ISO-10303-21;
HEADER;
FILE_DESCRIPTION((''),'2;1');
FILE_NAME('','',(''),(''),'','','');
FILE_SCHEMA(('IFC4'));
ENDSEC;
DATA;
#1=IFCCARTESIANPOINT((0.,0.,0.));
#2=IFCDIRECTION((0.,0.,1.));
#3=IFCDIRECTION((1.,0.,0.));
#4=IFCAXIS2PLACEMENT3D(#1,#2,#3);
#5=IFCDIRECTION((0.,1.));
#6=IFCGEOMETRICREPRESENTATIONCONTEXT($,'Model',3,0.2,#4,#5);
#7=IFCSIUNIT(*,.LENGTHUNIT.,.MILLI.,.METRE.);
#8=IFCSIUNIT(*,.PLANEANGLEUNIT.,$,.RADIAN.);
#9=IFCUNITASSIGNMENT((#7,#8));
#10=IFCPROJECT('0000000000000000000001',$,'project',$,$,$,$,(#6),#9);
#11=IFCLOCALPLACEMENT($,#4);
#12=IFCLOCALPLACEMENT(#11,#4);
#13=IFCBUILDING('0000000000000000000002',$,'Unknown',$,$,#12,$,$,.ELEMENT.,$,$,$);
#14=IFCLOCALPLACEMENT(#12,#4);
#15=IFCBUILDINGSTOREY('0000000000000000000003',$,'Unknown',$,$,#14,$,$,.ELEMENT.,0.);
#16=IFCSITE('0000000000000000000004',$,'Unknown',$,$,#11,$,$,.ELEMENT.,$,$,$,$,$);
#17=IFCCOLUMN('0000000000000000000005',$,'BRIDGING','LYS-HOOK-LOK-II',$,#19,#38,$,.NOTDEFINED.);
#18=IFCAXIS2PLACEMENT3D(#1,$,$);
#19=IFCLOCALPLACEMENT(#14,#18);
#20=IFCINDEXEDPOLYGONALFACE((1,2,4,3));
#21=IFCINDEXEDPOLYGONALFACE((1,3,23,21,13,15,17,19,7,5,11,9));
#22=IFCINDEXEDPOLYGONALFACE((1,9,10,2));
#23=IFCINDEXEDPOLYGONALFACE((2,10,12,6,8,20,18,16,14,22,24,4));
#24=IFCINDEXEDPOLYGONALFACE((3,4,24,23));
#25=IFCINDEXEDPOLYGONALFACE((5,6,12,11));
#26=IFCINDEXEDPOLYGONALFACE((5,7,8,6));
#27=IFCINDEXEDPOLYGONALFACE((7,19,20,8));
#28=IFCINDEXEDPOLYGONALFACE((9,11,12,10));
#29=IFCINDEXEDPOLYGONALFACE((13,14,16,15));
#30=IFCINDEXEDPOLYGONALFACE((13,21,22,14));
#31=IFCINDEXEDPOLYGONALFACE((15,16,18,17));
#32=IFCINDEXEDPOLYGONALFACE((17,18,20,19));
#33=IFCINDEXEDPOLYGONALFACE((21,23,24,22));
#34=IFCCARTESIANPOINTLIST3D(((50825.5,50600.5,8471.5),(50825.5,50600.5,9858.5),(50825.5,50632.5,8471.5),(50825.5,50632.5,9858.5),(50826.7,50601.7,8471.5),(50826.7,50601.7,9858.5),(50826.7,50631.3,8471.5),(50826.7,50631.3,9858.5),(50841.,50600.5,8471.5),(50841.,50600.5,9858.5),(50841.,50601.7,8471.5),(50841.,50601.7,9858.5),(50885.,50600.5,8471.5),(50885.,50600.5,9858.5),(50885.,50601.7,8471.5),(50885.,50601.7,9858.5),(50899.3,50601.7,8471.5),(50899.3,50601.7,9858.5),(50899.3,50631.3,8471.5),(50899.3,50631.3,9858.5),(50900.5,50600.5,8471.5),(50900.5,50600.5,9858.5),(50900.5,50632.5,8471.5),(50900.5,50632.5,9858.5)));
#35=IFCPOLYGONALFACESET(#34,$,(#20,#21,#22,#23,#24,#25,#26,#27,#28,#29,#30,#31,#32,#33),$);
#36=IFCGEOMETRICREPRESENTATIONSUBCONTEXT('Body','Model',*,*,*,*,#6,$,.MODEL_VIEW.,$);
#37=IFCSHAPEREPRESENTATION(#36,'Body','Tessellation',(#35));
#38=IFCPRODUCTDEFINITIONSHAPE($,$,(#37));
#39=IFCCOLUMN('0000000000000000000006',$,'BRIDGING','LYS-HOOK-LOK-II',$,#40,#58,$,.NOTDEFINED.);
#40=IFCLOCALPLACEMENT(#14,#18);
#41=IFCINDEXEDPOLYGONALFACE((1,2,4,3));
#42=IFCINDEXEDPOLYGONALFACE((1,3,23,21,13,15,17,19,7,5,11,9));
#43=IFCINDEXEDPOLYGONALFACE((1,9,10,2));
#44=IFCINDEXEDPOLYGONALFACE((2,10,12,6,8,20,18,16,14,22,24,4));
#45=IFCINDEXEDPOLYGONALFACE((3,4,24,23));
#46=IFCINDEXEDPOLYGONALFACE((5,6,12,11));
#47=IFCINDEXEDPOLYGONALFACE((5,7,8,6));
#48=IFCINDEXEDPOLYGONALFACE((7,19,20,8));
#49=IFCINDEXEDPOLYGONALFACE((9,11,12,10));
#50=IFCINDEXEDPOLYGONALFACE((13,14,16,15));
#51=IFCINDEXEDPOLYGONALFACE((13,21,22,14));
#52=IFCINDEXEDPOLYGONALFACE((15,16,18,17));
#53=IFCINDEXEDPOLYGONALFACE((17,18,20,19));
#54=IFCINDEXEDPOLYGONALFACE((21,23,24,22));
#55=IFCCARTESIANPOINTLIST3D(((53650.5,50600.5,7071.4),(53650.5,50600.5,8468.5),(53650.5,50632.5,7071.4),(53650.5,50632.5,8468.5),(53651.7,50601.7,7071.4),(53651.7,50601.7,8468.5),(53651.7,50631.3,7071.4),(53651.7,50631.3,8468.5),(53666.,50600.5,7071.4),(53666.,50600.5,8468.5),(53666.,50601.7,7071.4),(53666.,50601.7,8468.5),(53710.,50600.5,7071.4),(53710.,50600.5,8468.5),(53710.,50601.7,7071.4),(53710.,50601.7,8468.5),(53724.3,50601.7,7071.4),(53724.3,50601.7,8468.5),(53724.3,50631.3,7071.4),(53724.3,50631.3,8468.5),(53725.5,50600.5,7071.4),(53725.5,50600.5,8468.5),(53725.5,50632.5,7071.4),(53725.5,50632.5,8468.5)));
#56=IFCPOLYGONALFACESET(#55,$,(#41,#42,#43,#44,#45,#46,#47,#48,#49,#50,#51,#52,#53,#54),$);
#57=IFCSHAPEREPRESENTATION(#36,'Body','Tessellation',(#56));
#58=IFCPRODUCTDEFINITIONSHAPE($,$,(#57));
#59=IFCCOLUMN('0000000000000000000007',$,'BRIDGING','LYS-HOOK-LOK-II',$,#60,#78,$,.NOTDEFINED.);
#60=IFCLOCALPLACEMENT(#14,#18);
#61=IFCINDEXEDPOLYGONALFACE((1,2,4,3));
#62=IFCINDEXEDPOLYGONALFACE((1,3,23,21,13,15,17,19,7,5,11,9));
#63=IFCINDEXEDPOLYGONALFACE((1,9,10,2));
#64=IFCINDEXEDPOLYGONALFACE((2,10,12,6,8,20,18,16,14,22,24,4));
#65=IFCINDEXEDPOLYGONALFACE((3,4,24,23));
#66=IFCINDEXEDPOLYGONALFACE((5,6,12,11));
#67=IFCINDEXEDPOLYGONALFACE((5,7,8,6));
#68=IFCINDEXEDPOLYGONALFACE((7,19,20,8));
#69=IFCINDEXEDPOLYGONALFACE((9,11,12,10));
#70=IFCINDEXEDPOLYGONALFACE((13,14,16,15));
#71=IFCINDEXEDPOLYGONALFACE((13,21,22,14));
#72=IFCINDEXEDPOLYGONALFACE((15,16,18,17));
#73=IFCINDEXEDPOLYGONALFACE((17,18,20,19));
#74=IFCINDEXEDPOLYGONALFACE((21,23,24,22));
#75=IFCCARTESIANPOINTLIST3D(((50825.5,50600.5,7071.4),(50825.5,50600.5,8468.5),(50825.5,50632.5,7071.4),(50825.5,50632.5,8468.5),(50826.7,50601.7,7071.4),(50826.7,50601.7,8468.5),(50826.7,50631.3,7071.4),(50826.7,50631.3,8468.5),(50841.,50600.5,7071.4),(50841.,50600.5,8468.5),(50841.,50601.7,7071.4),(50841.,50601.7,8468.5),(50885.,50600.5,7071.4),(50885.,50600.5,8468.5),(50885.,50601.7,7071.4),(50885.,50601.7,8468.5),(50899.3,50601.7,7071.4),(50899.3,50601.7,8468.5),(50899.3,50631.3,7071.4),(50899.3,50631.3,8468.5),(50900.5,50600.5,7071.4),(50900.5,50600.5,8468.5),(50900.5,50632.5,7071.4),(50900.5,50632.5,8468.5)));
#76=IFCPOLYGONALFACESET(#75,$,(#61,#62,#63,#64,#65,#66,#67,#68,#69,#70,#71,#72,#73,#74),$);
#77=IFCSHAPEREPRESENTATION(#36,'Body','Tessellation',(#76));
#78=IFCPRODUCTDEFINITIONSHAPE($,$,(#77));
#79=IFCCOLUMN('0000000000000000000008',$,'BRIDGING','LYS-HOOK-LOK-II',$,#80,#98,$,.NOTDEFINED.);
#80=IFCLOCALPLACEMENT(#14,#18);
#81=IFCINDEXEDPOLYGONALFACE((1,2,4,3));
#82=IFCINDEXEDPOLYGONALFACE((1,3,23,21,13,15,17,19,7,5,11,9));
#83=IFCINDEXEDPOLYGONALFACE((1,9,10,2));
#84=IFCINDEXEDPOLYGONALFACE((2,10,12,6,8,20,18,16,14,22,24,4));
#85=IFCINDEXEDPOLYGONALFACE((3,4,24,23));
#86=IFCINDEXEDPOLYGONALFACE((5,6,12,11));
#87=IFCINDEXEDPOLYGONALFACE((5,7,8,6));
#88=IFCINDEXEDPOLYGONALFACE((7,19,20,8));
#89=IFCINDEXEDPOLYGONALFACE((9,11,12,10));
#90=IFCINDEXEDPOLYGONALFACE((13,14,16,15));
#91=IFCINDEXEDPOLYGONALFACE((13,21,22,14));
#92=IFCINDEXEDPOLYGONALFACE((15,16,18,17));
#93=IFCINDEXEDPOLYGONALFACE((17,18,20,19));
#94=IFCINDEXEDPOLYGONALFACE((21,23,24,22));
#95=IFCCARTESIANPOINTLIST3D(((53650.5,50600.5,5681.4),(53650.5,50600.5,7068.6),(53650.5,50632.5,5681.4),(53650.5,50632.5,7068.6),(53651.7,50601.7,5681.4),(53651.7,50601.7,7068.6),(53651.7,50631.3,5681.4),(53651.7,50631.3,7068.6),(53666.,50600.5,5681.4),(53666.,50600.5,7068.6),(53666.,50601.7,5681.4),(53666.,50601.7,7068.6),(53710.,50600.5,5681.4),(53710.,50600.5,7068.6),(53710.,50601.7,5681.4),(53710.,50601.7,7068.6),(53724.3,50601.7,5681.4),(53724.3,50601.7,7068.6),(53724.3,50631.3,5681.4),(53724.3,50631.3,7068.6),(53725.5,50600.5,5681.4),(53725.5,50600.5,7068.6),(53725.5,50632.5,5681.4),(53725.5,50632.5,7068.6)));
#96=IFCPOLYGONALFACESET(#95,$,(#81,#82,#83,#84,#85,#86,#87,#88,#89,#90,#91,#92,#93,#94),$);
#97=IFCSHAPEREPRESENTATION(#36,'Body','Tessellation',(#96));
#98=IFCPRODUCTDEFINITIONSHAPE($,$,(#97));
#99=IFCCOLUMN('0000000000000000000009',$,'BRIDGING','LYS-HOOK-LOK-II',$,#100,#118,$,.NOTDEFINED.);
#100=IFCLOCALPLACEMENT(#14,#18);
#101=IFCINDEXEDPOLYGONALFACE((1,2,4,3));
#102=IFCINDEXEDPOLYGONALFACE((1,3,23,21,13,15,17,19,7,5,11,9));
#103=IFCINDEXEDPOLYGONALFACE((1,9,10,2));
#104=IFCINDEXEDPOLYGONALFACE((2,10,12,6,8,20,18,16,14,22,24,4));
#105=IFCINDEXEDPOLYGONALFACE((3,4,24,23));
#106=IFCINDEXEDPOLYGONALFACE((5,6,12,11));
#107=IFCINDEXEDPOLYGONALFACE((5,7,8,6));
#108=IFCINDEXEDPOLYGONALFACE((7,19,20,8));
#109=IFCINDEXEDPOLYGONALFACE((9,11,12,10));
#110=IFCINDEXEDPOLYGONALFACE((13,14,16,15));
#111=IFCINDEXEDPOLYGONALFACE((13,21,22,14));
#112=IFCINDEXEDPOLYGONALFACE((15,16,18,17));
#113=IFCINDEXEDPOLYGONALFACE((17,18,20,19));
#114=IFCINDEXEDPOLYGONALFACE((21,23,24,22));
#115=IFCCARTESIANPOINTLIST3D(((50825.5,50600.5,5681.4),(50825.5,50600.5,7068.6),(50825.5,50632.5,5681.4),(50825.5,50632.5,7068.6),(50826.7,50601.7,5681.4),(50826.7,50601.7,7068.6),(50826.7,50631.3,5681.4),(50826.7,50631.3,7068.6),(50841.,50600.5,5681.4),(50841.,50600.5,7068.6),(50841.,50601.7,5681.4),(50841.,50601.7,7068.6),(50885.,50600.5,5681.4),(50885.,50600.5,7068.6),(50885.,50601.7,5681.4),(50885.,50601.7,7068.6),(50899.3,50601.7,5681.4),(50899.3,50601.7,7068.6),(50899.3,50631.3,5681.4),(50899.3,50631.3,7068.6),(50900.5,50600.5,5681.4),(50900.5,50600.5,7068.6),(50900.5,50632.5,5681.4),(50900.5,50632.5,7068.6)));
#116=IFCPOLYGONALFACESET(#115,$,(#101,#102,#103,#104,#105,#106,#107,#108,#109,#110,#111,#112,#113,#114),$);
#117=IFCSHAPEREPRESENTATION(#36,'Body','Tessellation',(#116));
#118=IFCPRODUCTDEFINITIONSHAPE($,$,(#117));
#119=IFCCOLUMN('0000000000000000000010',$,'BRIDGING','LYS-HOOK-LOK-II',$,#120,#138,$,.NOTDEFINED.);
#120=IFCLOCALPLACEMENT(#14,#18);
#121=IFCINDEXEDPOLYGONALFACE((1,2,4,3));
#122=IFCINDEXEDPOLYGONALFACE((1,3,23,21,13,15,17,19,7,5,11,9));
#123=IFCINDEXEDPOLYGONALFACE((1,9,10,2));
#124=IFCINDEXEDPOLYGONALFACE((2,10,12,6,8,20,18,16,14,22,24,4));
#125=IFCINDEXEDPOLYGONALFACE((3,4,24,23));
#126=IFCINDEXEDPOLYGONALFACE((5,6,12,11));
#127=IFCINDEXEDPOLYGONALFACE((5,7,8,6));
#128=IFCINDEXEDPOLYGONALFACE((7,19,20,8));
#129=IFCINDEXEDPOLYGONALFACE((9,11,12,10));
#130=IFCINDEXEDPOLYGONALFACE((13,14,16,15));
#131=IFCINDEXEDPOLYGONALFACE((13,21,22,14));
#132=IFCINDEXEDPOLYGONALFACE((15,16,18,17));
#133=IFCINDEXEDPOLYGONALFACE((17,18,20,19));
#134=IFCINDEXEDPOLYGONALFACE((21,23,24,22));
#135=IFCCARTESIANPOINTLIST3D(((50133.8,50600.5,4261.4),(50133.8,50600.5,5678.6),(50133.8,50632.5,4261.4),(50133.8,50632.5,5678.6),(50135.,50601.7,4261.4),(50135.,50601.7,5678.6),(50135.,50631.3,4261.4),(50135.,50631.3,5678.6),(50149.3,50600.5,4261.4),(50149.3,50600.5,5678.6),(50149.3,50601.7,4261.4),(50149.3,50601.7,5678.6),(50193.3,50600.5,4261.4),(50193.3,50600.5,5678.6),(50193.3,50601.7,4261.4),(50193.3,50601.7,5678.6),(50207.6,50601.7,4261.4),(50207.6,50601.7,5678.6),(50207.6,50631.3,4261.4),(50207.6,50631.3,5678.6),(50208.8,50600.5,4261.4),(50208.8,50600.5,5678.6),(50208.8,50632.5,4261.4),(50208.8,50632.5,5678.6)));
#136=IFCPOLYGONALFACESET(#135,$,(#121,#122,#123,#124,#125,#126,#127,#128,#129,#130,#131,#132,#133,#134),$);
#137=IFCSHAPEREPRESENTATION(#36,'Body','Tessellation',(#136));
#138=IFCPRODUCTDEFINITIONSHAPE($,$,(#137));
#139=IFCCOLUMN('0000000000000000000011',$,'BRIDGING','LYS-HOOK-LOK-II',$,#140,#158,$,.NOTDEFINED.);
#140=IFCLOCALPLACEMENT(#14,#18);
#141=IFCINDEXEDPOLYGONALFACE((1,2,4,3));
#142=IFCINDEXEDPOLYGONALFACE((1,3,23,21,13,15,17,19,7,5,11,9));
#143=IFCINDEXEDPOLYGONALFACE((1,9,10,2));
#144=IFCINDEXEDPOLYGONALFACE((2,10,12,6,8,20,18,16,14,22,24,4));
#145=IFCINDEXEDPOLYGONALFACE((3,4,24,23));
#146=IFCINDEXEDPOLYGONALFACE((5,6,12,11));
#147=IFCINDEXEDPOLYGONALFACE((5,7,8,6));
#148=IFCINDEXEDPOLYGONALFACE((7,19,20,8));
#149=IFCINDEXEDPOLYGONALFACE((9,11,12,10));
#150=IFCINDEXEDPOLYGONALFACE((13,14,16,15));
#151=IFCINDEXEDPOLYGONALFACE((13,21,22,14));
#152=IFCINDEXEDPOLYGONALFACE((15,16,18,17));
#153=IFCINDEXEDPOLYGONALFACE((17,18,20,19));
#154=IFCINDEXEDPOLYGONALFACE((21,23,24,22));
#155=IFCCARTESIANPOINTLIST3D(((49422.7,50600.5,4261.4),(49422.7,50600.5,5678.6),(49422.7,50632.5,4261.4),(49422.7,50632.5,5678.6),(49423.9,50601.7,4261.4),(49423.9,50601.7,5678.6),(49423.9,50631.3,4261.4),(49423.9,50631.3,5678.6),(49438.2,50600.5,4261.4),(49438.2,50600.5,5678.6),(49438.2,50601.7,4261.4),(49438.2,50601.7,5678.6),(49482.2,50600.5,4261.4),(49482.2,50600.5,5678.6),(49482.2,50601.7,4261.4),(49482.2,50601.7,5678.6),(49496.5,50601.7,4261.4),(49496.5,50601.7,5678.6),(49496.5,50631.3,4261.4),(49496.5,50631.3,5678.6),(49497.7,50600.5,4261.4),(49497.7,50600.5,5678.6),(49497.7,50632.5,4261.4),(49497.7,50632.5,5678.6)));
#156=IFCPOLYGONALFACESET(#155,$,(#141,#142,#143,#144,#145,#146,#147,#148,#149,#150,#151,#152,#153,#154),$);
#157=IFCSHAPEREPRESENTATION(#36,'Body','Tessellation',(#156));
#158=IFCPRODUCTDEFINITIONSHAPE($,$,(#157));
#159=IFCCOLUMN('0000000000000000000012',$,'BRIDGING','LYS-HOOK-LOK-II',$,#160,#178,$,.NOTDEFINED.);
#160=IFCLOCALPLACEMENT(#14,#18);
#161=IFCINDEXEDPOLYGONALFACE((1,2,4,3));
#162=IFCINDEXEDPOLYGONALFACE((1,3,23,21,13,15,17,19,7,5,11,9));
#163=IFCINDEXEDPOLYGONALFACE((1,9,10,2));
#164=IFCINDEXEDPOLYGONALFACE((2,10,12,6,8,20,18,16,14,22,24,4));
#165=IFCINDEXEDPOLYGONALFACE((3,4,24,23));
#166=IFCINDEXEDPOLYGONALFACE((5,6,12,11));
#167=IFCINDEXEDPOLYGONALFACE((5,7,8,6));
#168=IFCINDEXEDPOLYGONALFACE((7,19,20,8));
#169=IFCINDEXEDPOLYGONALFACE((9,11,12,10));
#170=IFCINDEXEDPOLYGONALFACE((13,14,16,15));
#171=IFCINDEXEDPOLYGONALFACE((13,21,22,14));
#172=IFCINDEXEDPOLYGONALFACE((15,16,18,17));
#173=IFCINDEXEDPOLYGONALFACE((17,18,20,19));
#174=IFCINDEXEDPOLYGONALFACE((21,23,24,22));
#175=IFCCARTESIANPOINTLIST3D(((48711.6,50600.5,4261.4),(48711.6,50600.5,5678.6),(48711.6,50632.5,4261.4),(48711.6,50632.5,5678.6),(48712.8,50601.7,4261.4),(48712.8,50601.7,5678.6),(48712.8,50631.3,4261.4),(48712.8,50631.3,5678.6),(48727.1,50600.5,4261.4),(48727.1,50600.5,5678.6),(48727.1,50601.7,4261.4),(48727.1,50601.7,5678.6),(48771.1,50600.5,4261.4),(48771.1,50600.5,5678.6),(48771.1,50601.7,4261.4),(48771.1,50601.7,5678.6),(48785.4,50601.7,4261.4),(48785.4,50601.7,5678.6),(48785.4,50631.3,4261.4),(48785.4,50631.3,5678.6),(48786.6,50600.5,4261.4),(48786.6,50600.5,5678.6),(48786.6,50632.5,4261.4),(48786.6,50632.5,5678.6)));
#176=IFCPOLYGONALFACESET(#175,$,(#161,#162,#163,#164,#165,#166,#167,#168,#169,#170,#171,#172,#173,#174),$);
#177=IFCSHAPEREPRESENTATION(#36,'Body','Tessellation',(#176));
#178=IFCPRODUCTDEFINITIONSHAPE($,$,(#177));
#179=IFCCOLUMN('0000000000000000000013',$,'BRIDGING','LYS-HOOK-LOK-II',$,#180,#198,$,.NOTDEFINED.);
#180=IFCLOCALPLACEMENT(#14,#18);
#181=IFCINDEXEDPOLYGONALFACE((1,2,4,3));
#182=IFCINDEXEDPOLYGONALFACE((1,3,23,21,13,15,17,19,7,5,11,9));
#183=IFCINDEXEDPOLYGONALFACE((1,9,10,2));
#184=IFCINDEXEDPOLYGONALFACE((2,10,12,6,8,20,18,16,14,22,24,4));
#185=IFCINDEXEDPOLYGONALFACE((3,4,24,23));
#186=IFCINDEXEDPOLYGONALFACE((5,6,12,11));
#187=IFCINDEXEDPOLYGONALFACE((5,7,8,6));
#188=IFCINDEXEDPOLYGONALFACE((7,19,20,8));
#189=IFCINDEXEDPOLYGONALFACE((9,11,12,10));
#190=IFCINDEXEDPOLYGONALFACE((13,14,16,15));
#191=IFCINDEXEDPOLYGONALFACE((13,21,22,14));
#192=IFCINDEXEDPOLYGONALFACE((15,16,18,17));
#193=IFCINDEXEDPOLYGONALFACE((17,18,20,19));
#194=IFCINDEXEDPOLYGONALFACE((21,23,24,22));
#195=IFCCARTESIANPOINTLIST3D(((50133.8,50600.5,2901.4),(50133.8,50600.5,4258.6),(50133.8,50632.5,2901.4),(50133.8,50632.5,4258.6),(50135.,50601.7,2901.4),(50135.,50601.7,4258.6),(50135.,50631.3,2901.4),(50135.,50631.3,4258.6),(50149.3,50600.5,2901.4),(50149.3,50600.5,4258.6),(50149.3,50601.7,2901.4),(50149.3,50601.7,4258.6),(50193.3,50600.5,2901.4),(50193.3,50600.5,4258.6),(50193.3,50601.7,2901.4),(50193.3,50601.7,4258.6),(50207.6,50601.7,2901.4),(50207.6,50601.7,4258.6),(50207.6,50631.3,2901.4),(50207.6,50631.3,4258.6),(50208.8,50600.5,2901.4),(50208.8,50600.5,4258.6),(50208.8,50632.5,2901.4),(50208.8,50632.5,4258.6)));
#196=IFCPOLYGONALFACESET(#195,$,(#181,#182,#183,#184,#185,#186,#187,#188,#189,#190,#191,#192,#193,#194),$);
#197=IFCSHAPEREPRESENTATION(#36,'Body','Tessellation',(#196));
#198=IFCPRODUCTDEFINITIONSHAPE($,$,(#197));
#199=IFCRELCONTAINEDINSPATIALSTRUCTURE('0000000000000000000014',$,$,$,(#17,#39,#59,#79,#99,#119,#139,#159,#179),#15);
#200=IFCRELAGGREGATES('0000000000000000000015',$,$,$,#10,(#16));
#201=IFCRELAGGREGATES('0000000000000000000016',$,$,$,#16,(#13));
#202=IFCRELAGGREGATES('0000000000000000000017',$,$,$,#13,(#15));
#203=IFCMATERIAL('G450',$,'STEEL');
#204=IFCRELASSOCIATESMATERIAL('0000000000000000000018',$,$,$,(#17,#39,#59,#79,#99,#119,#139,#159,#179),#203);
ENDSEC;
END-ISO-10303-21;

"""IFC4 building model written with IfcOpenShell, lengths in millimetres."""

from ifc_helpers import new_model, si_unit, direction, frame, origin_with_axes, place, context, subcontext, project, spatial, line, indexed_curve, outline, extrude, material, element, save


model = new_model("IFC4")

# Units and contexts
model_context = context("Model", 3, precision=0.2, world=origin_with_axes(), true_north=direction((0.0, 1.0)))
body_context = subcontext(model_context, "Body", "Model", "MODEL_VIEW")
ifc_project = project(units=[si_unit("LENGTHUNIT", "METRE", prefix="MILLI"), si_unit("PLANEANGLEUNIT", "RADIAN")], contexts=[model_context])

# Site, building, storey
site_placement = place(None, origin_with_axes())
site = spatial("IfcSite", under=ifc_project, at=site_placement, Name="Unknown", CompositionType="ELEMENT")
building_placement = place(site_placement, origin_with_axes())
building = spatial("IfcBuilding", under=site, at=building_placement, Name="Unknown", CompositionType="ELEMENT")
storey_placement = place(building_placement, origin_with_axes())
storey = spatial("IfcBuildingStorey", under=building, at=storey_placement, Name="Unknown", CompositionType="ELEMENT", Elevation=0.0)

# Columns
ifc_material_1 = material(Name="G450", Category="STEEL")
column_1_placement = place(storey_placement, frame((50863.0, 50616.5, 8471.5), z_axis=(0.0, -1.0, 0.0), x_axis=(0.0, 0.0, 1.0)))
element("IfcColumn", 1, at=column_1_placement, inside=storey, material=ifc_material_1, Name="BRIDGING", Description="LYS-HOOK-LOK-II", PredefinedType="NOTDEFINED", context=body_context, shape_type="SolidModel", body=[
    extrude(outline(indexed_curve([(16.0, -37.5), (16.0, -22.0), (14.8, -22.0), (14.8, -36.3), (-14.8, -36.3), (-14.8, 36.3), (14.8, 36.3), (14.8, 22.0), (16.0, 22.0), (16.0, 37.5), (-16.0, 37.5), (-16.0, -37.5)], segments=[line(1, 2, 3, 4, 5, 6, 7, 8, 9, 10, 11, 12, 1)])), frame((0.0, 0.0, 0.0), z_axis=(-1.0, 0.0, 0.0), x_axis=(0.0, 0.0, 1.0)), (0.0, 0.0, -1.0), 1387.0),
])
for number, where, z_axis, x_axis, name in (
    (2, (53688.0, 50616.5, 7071.4), (0.0, -1.0, 0.0), (0.0, 0.0, 1.0), "BRIDGING"),
    (3, (50863.0, 50616.5, 7071.4), (0.0, -1.0, 0.0), (0.0, 0.0, 1.0), "BRIDGING"),
):
    element("IfcColumn", number, at=place(storey_placement, frame(where, z_axis=z_axis, x_axis=x_axis)), inside=storey, material=ifc_material_1, Name=name, Description="LYS-HOOK-LOK-II", PredefinedType="NOTDEFINED", context=body_context, shape_type="SolidModel", body=[
        extrude(outline(indexed_curve([(16.0, -37.5), (16.0, -22.0), (14.8, -22.0), (14.8, -36.3), (-14.8, -36.3), (-14.8, 36.3), (14.8, 36.3), (14.8, 22.0), (16.0, 22.0), (16.0, 37.5), (-16.0, 37.5), (-16.0, -37.5)], segments=[line(1, 2, 3, 4, 5, 6, 7, 8, 9, 10, 11, 12, 1)])), frame((0.0, 0.0, 0.0), z_axis=(-1.0, 0.0, 0.0), x_axis=(0.0, 0.0, 1.0)), (0.0, 0.0, -1.0), 1397.1),
    ])
for number, where, z_axis, x_axis, name in (
    (4, (53688.0, 50616.5, 5681.4), (0.0, -1.0, 0.0), (0.0, 0.0, 1.0), "BRIDGING"),
    (5, (50863.0, 50616.5, 5681.4), (0.0, -1.0, 0.0), (0.0, 0.0, 1.0), "BRIDGING"),
):
    element("IfcColumn", number, at=place(storey_placement, frame(where, z_axis=z_axis, x_axis=x_axis)), inside=storey, material=ifc_material_1, Name=name, Description="LYS-HOOK-LOK-II", PredefinedType="NOTDEFINED", context=body_context, shape_type="SolidModel", body=[
        extrude(outline(indexed_curve([(16.0, -37.5), (16.0, -22.0), (14.8, -22.0), (14.8, -36.3), (-14.8, -36.3), (-14.8, 36.3), (14.8, 36.3), (14.8, 22.0), (16.0, 22.0), (16.0, 37.5), (-16.0, 37.5), (-16.0, -37.5)], segments=[line(1, 2, 3, 4, 5, 6, 7, 8, 9, 10, 11, 12, 1)])), frame((0.0, 0.0, 0.0), z_axis=(-1.0, 0.0, 0.0), x_axis=(0.0, 0.0, 1.0)), (0.0, 0.0, -1.0), 1387.2),
    ])
for number, where, z_axis, x_axis, name in (
    (6, (50171.3, 50616.5, 4261.4), (0.0, -1.0, 0.0), (0.0, 0.0, 1.0), "BRIDGING"),
    (7, (49460.2, 50616.5, 4261.4), (0.0, -1.0, 0.0), (0.0, 0.0, 1.0), "BRIDGING"),
    (8, (48749.1, 50616.5, 4261.4), (0.0, -1.0, 0.0), (0.0, 0.0, 1.0), "BRIDGING"),
):
    element("IfcColumn", number, at=place(storey_placement, frame(where, z_axis=z_axis, x_axis=x_axis)), inside=storey, material=ifc_material_1, Name=name, Description="LYS-HOOK-LOK-II", PredefinedType="NOTDEFINED", context=body_context, shape_type="SolidModel", body=[
        extrude(outline(indexed_curve([(16.0, -37.5), (16.0, -22.0), (14.8, -22.0), (14.8, -36.3), (-14.8, -36.3), (-14.8, 36.3), (14.8, 36.3), (14.8, 22.0), (16.0, 22.0), (16.0, 37.5), (-16.0, 37.5), (-16.0, -37.5)], segments=[line(1, 2, 3, 4, 5, 6, 7, 8, 9, 10, 11, 12, 1)])), frame((0.0, 0.0, 0.0), z_axis=(-1.0, 0.0, 0.0), x_axis=(0.0, 0.0, 1.0)), (0.0, 0.0, -1.0), 1417.2),
    ])
for number, where, z_axis, x_axis, name in (
    (9, (50171.3, 50616.5, 2901.4), (0.0, -1.0, 0.0), (0.0, 0.0, 1.0), "BRIDGING"),
):
    element("IfcColumn", number, at=place(storey_placement, frame(where, z_axis=z_axis, x_axis=x_axis)), inside=storey, material=ifc_material_1, Name=name, Description="LYS-HOOK-LOK-II", PredefinedType="NOTDEFINED", context=body_context, shape_type="SolidModel", body=[
        extrude(outline(indexed_curve([(16.0, -37.5), (16.0, -22.0), (14.8, -22.0), (14.8, -36.3), (-14.8, -36.3), (-14.8, 36.3), (14.8, 36.3), (14.8, 22.0), (16.0, 22.0), (16.0, 37.5), (-16.0, 37.5), (-16.0, -37.5)], segments=[line(1, 2, 3, 4, 5, 6, 7, 8, 9, 10, 11, 12, 1)])), frame((0.0, 0.0, 0.0), z_axis=(-1.0, 0.0, 0.0), x_axis=(0.0, 0.0, 1.0)), (0.0, 0.0, -1.0), 1357.2),
    ])

save(model, "model.ifc")
